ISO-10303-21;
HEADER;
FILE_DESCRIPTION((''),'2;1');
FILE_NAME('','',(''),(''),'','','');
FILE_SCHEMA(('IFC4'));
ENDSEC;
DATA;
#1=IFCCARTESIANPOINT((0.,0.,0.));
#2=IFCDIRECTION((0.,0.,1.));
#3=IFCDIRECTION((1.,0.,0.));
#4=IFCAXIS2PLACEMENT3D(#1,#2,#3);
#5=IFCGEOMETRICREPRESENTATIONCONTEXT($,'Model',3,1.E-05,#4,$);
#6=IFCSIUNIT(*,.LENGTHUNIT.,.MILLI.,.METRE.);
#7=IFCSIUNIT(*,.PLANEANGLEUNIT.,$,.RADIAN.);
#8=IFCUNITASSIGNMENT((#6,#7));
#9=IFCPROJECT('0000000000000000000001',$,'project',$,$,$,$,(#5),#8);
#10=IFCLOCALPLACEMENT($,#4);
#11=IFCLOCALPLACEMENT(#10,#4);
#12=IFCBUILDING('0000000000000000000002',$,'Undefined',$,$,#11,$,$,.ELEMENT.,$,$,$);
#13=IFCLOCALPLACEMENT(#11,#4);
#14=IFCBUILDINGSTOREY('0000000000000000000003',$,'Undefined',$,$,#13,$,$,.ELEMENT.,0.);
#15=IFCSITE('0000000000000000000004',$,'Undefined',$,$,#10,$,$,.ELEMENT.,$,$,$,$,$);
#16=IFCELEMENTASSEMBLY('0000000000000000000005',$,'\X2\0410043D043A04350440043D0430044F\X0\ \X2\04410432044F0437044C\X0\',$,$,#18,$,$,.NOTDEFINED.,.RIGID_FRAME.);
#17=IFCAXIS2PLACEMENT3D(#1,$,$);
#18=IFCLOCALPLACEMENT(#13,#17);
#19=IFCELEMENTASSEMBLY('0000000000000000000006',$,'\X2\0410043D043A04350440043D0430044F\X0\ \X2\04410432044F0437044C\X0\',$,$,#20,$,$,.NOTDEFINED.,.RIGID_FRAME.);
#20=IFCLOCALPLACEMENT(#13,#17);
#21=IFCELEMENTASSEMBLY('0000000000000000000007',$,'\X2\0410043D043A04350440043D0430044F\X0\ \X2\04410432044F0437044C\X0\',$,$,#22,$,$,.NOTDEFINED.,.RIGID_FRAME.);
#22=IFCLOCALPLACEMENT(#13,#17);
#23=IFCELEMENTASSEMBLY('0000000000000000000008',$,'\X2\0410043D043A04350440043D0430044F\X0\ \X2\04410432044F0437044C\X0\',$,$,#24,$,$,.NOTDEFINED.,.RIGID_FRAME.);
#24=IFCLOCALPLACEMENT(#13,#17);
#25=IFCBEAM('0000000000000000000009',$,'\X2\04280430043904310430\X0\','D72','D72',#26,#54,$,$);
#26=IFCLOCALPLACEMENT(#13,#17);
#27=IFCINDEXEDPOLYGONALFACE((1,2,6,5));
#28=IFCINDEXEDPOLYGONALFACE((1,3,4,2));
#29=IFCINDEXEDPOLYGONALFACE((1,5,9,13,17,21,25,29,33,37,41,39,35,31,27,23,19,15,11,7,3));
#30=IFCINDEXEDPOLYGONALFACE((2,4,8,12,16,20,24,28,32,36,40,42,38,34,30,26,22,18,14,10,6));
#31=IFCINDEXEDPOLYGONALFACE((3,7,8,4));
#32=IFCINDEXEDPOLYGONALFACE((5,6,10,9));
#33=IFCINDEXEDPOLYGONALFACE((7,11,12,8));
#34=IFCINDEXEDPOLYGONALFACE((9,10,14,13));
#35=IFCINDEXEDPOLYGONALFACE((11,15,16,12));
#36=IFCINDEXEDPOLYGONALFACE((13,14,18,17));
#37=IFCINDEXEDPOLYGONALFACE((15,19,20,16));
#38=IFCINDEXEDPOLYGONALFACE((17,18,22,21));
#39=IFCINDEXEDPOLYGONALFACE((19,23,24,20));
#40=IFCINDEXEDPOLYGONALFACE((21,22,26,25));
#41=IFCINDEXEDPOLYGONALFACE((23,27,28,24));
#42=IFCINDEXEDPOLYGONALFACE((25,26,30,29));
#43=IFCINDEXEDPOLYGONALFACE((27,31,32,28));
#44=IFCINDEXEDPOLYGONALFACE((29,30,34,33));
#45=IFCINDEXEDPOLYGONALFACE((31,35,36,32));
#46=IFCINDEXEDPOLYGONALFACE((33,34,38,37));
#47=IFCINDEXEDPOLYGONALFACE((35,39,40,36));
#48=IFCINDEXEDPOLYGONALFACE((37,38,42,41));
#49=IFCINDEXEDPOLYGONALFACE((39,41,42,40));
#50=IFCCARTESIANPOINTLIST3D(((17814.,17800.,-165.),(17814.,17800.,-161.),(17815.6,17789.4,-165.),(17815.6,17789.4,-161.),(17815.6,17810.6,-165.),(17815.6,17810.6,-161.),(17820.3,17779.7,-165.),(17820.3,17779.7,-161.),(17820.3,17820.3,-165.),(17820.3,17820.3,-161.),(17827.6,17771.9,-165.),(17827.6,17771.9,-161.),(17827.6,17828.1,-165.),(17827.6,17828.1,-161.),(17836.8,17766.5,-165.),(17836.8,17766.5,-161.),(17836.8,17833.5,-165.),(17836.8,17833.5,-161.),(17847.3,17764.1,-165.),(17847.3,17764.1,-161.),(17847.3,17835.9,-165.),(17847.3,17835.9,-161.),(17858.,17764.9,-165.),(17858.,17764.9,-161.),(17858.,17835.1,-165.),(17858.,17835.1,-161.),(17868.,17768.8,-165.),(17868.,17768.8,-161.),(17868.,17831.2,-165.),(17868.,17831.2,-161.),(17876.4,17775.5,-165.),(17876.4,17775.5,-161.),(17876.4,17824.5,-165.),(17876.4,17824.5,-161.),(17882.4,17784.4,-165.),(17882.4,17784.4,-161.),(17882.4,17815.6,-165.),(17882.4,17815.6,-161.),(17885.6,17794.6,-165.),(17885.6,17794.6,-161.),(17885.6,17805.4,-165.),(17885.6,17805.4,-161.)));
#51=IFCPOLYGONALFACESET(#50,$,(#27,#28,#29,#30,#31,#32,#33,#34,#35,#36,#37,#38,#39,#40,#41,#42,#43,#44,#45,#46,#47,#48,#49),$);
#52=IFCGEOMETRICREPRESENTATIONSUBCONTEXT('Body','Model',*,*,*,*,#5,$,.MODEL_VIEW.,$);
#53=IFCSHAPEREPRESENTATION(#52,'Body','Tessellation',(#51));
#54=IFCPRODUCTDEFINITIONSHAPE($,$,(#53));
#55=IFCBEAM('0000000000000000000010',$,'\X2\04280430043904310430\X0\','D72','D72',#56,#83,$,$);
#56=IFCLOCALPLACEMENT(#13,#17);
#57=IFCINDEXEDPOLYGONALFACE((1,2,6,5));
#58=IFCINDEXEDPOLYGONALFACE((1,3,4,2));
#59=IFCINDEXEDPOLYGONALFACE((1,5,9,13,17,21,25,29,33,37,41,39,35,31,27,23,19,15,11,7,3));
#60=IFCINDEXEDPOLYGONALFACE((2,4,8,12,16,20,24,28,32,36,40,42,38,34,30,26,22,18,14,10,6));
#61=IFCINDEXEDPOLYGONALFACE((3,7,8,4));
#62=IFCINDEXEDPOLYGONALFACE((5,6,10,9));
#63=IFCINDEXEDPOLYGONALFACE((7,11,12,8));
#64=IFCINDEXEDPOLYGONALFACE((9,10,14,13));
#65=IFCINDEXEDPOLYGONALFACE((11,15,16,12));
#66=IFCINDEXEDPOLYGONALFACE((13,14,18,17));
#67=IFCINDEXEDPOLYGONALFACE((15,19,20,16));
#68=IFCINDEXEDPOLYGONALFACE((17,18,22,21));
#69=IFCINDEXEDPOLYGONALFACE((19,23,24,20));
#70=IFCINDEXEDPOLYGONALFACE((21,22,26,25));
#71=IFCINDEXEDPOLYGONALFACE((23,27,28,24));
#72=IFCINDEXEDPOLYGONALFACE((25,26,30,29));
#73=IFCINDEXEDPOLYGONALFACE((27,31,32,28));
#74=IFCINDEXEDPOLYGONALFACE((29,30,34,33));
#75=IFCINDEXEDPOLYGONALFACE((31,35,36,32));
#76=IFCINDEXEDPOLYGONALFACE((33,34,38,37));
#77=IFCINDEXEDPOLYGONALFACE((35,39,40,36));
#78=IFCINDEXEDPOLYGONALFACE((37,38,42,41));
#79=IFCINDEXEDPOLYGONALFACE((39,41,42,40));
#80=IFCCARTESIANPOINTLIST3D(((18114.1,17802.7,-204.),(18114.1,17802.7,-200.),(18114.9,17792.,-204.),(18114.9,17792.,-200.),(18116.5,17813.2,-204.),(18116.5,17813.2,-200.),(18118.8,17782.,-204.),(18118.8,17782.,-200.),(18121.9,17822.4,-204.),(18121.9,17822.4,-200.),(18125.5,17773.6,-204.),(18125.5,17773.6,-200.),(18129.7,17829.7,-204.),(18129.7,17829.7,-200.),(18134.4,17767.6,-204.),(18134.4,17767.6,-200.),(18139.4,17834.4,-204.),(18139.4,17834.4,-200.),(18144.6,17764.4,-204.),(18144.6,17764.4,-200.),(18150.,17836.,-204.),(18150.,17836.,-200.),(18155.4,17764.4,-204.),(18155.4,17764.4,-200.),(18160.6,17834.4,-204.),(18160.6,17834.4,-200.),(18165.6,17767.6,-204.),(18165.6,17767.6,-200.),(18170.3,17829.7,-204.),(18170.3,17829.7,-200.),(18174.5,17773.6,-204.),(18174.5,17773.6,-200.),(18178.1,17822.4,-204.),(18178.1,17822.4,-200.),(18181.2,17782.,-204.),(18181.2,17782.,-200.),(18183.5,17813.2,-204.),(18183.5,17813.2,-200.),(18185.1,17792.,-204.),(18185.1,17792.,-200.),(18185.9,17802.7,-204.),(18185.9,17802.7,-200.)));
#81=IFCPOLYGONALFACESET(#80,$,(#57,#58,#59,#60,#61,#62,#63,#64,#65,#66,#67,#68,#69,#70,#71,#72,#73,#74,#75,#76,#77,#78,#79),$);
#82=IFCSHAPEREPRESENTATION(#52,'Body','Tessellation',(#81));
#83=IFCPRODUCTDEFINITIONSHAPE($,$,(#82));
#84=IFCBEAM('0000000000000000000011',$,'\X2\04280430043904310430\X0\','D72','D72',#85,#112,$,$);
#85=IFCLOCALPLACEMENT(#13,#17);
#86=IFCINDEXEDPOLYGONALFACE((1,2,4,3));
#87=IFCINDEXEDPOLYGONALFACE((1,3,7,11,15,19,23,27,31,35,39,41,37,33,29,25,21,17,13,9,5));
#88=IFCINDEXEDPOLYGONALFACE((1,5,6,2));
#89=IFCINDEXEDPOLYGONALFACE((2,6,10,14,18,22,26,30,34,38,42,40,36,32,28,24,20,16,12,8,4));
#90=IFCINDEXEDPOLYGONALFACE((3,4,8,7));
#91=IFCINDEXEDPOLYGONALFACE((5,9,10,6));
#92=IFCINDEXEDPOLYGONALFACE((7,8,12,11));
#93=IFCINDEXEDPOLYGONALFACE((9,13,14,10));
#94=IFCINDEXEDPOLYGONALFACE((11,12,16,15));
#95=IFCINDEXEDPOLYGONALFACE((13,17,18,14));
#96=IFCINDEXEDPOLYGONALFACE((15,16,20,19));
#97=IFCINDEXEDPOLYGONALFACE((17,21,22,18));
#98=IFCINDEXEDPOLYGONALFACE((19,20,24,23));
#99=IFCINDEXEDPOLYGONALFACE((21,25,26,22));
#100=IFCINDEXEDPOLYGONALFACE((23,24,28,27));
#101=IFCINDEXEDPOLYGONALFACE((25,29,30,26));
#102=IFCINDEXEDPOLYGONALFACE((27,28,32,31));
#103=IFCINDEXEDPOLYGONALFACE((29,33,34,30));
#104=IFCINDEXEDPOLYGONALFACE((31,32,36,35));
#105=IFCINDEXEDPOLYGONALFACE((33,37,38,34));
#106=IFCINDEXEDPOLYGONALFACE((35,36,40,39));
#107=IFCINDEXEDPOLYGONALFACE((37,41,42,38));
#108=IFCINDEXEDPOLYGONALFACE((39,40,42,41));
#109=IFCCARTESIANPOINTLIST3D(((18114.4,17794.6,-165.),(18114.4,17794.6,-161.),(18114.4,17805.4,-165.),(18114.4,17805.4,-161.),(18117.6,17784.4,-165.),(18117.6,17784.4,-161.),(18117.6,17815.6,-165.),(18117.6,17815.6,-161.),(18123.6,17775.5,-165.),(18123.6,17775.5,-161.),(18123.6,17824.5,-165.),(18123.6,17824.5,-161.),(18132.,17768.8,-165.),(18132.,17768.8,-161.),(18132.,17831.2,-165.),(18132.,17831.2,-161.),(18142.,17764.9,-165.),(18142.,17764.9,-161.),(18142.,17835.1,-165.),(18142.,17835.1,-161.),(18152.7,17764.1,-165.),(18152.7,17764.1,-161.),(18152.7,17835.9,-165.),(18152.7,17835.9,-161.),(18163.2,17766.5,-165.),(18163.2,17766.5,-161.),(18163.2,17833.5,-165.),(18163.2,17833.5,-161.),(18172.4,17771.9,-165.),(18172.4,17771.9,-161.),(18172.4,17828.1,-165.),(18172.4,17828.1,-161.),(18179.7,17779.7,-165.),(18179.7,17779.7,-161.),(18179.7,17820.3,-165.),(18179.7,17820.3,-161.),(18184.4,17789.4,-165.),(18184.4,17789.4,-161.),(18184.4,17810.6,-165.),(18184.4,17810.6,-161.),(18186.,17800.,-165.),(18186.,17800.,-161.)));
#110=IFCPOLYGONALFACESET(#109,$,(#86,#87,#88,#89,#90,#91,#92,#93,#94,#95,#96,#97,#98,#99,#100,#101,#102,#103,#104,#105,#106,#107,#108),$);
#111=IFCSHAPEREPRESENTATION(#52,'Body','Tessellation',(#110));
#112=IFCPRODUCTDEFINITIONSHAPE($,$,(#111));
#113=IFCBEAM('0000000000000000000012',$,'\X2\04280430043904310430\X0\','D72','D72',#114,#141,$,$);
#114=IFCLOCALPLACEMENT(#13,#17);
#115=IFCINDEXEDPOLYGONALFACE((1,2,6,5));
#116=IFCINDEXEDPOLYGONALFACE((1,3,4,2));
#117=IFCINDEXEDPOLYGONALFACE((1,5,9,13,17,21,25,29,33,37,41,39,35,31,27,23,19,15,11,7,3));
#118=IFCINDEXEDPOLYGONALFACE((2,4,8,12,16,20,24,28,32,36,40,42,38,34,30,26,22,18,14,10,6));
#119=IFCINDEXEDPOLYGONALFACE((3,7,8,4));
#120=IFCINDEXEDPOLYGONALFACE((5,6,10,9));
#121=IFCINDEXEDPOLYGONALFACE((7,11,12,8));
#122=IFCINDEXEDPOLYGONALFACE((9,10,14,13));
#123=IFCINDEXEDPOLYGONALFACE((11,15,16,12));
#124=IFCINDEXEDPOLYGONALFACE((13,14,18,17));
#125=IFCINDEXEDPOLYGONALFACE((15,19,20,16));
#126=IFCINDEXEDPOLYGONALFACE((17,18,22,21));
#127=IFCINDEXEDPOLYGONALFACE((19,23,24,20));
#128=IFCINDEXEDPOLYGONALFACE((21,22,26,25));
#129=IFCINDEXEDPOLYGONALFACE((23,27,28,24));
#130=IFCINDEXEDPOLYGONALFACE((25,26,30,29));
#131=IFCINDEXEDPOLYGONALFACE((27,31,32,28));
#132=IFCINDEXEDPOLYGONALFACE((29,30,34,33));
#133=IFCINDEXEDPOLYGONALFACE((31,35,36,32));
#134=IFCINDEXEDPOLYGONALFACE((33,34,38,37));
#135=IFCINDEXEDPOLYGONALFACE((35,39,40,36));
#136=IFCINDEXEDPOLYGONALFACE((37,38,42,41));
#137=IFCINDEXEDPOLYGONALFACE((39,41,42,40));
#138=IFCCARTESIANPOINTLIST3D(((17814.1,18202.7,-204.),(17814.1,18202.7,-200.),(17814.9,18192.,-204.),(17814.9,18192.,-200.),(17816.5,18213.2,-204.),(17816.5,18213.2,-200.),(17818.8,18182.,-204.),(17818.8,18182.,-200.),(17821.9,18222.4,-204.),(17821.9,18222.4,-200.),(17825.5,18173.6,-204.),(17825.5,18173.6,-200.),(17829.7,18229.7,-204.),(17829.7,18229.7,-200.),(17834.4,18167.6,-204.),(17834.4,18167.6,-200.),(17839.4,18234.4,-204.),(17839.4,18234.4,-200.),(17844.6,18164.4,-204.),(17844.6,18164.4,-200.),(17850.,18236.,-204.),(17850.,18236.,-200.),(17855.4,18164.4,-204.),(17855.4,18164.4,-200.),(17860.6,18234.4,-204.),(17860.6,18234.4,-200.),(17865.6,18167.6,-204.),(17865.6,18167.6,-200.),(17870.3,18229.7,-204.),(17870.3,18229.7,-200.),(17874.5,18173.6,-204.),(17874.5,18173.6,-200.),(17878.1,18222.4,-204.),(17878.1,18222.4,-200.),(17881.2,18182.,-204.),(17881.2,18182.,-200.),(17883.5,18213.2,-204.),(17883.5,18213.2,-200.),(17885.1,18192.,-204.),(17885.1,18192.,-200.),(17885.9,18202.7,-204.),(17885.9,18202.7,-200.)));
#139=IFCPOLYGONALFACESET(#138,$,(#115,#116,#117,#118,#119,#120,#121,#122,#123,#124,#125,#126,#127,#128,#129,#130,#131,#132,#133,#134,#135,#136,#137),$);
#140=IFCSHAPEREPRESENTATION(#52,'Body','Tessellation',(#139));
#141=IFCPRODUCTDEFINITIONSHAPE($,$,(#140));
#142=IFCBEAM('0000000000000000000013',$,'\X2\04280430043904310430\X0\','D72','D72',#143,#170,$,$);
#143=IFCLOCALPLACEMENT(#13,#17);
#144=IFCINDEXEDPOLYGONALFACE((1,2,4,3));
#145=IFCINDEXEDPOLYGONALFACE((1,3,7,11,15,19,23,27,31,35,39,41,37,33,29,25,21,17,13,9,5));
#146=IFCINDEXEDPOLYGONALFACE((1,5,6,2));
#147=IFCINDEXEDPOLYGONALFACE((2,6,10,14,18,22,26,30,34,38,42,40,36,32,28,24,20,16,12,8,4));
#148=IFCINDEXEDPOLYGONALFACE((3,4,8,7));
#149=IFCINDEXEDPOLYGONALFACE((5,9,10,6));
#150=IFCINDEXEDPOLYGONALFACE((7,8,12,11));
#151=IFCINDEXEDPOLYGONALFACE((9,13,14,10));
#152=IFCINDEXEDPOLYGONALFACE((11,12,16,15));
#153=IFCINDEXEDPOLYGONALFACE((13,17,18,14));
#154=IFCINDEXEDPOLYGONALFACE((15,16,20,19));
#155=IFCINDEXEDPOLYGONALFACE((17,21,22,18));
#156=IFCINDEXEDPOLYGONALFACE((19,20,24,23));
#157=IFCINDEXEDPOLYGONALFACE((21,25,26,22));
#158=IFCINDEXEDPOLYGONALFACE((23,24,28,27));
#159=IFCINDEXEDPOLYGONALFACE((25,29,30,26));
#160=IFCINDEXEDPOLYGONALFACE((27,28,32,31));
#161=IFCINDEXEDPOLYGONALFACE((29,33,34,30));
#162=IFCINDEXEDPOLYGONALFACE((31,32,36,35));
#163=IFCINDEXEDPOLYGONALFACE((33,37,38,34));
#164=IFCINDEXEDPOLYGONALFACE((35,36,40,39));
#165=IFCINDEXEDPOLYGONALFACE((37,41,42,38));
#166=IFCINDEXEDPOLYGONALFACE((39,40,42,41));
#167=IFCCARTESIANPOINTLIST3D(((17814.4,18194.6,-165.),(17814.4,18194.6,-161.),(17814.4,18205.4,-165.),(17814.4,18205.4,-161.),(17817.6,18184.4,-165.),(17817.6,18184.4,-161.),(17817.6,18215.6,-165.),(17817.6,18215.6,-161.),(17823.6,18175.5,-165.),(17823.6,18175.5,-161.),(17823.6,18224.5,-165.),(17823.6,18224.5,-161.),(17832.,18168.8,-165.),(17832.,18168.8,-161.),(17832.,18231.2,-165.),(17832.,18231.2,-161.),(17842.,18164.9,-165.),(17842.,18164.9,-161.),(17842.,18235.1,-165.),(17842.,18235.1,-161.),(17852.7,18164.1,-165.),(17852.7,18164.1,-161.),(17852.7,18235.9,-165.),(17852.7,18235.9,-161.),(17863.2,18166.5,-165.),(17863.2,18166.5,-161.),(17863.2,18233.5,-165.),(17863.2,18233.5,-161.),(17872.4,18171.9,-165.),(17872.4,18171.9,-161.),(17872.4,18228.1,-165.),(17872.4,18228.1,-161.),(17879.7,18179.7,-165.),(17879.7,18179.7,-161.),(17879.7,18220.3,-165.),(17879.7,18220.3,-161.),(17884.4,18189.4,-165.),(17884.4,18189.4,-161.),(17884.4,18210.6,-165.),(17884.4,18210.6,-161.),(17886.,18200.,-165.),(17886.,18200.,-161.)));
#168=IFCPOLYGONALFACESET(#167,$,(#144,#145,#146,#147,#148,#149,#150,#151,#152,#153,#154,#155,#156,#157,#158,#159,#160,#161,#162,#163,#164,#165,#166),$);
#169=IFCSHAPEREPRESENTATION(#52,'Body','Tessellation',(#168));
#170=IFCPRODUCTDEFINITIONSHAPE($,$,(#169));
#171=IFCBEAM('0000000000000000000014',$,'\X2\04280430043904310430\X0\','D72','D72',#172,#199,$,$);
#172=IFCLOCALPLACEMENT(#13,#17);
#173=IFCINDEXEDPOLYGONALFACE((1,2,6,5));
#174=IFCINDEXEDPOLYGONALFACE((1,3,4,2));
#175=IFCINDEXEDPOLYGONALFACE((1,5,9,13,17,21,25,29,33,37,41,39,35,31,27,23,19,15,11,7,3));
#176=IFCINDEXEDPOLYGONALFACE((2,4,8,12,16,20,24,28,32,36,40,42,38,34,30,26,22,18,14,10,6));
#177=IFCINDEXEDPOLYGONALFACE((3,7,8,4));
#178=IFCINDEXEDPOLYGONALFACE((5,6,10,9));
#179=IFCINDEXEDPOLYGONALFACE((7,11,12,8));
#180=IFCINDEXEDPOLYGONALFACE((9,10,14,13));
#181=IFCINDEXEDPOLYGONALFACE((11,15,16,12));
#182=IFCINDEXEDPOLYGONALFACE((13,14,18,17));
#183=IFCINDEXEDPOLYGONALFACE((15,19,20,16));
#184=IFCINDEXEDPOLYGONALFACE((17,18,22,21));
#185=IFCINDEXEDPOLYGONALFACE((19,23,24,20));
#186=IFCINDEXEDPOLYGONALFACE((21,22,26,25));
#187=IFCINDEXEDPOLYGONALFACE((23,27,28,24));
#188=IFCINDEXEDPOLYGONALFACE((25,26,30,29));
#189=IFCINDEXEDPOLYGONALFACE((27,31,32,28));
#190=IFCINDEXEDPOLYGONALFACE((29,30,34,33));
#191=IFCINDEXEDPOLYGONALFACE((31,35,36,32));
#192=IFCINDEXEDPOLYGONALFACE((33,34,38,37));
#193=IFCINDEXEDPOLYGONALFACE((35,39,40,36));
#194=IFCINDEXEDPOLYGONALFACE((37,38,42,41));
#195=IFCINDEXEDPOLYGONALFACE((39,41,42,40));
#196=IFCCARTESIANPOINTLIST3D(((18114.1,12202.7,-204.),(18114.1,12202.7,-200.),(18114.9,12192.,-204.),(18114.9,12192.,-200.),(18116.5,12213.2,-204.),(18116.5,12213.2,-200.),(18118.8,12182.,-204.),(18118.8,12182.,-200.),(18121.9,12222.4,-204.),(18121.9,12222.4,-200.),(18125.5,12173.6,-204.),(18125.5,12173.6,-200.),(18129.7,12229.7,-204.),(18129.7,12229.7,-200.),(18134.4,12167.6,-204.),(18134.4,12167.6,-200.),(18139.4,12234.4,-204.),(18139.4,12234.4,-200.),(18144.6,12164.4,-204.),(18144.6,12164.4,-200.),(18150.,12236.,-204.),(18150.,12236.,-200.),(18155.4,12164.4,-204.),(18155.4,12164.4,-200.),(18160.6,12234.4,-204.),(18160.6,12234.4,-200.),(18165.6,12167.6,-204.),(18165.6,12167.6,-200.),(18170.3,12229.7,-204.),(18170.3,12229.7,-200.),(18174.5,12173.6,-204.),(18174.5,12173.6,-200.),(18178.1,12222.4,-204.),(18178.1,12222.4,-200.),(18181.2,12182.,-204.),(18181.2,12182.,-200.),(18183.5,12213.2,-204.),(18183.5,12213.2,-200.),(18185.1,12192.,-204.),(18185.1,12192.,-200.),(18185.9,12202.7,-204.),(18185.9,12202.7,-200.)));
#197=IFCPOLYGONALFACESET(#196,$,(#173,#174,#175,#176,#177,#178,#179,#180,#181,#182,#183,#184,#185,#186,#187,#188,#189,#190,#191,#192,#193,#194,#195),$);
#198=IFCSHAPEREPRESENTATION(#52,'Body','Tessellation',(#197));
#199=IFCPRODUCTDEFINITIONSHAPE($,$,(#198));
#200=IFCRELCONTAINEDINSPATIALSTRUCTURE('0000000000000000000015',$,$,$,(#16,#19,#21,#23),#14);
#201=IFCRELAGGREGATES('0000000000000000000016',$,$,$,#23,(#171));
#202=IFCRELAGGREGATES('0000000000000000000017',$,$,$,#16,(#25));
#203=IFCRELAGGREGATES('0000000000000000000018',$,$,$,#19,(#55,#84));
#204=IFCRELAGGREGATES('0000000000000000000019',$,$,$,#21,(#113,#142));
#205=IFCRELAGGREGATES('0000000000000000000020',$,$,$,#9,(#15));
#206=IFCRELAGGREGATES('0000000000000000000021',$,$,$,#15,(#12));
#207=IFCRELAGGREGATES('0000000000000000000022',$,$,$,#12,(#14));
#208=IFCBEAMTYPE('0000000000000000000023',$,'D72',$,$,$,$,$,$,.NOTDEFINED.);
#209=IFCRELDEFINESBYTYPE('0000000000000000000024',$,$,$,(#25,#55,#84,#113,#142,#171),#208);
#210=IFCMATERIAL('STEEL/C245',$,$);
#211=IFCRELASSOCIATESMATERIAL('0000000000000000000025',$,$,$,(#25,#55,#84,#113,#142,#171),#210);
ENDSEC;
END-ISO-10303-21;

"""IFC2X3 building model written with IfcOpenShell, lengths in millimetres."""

from ifc_helpers import new_model, si_unit, frame, origin_with_axes, origin_2d_with_axis, place, context, subcontext, project, spatial, circle, extrude, material, type_object, element, aggregate, save


model = new_model("IFC2X3")

# Units and contexts
model_context = context("Model", 3, precision=1e-05, world=origin_with_axes())
body_context = subcontext(model_context, "Body", "Model", "MODEL_VIEW")
ifc_project = project(units=[si_unit("LENGTHUNIT", "METRE", prefix="MILLI"), si_unit("PLANEANGLEUNIT", "RADIAN")], contexts=[model_context])

# Site, building, storey
site_placement = place(None, origin_with_axes())
site = spatial("IfcSite", under=ifc_project, at=site_placement, Name="Undefined", CompositionType="ELEMENT")
building_placement = place(site_placement, origin_with_axes())
building = spatial("IfcBuilding", under=site, at=building_placement, Name="Undefined", CompositionType="ELEMENT")
storey_placement = place(building_placement, origin_with_axes())
storey = spatial("IfcBuildingStorey", under=building, at=storey_placement, Name="Undefined", CompositionType="ELEMENT", Elevation=0.0)

# Element assemblies
assembly_1_placement = place(storey_placement, origin_with_axes())
assembly_1 = element("IfcElementAssembly", 1, at=assembly_1_placement, inside=storey, Name="Анкерная связь", AssemblyPlace="NOTDEFINED", PredefinedType="RIGID_FRAME")
ifc_material_1 = material(Name="STEEL/C245")
assembly_2_placement = place(storey_placement, origin_with_axes())
assembly_2 = element("IfcElementAssembly", 2, at=assembly_2_placement, inside=storey, Name="Анкерная связь", AssemblyPlace="NOTDEFINED", PredefinedType="RIGID_FRAME")
assembly_3_placement = place(storey_placement, origin_with_axes())
assembly_3 = element("IfcElementAssembly", 3, at=assembly_3_placement, inside=storey, Name="Анкерная связь", AssemblyPlace="NOTDEFINED", PredefinedType="RIGID_FRAME")

# Element assembly
assembly_4_placement = place(storey_placement, origin_with_axes())
assembly_4 = element("IfcElementAssembly", 4, at=assembly_4_placement, inside=storey, Name="Анкерная связь", AssemblyPlace="NOTDEFINED", PredefinedType="RIGID_FRAME")

# Beams
beam_type_1 = type_object("IfcBeamType", Name="D72", PredefinedType="NOTDEFINED")
beam_1_placement = place(assembly_1_placement, frame((17850.0, 17800.0, -161.0), z_axis=(0.0, -1.0, 0.0), x_axis=(0.0, 0.0, -1.0)))
beam_1 = element("IfcBeam", 5, at=beam_1_placement, type_object=beam_type_1, material=ifc_material_1, Name="Шайба", Description="D72", ObjectType="D72", context=body_context, shape_type="SweptSolid", body=[
    extrude(circle(Radius=36.0, at=origin_2d_with_axis()), frame((4.0, 0.0, 0.0), z_axis=(-1.0, 0.0, 0.0), x_axis=(0.0, -1.0, 0.0)), (0.0, 0.0, 1.0), 4.0),
])
beam_2_placement = place(assembly_2_placement, frame((18150.0, 17800.0, -200.0), z_axis=(-1.0, 0.0, 0.0), x_axis=(0.0, 0.0, -1.0)))
beam_2 = element("IfcBeam", 6, at=beam_2_placement, type_object=beam_type_1, material=ifc_material_1, Name="Шайба", Description="D72", ObjectType="D72", context=body_context, shape_type="SweptSolid", body=[
    extrude(circle(Radius=36.0, at=origin_2d_with_axis()), frame((4.0, 0.0, 0.0), z_axis=(-1.0, 0.0, 0.0), x_axis=(0.0, -1.0, 0.0)), (0.0, 0.0, 1.0), 4.0),
])
beam_3_placement = place(assembly_2_placement, frame((18150.0, 17800.0, -161.0), z_axis=(0.0, 1.0, 0.0), x_axis=(0.0, 0.0, -1.0)))
beam_3 = element("IfcBeam", 7, at=beam_3_placement, type_object=beam_type_1, material=ifc_material_1, Name="Шайба", Description="D72", ObjectType="D72", context=body_context, shape_type="SweptSolid", body=[
    extrude(circle(Radius=36.0, at=origin_2d_with_axis()), frame((4.0, 0.0, 0.0), z_axis=(-1.0, 0.0, 0.0), x_axis=(0.0, -1.0, 0.0)), (0.0, 0.0, 1.0), 4.0),
])
beam_4_placement = place(assembly_3_placement, frame((17850.0, 18200.0, -200.0), z_axis=(-1.0, 0.0, 0.0), x_axis=(0.0, 0.0, -1.0)))
beam_4 = element("IfcBeam", 8, at=beam_4_placement, type_object=beam_type_1, material=ifc_material_1, Name="Шайба", Description="D72", ObjectType="D72", context=body_context, shape_type="SweptSolid", body=[
    extrude(circle(Radius=36.0, at=origin_2d_with_axis()), frame((4.0, 0.0, 0.0), z_axis=(-1.0, 0.0, 0.0), x_axis=(0.0, -1.0, 0.0)), (0.0, 0.0, 1.0), 4.0),
])
beam_5_placement = place(assembly_3_placement, frame((17850.0, 18200.0, -161.0), z_axis=(0.0, 1.0, 0.0), x_axis=(0.0, 0.0, -1.0)))
beam_5 = element("IfcBeam", 9, at=beam_5_placement, type_object=beam_type_1, material=ifc_material_1, Name="Шайба", Description="D72", ObjectType="D72", context=body_context, shape_type="SweptSolid", body=[
    extrude(circle(Radius=36.0, at=origin_2d_with_axis()), frame((4.0, 0.0, 0.0), z_axis=(-1.0, 0.0, 0.0), x_axis=(0.0, -1.0, 0.0)), (0.0, 0.0, 1.0), 4.0),
])
beam_6_placement = place(assembly_4_placement, frame((18150.0, 12200.0, -200.0), z_axis=(-1.0, 0.0, 0.0), x_axis=(0.0, 0.0, -1.0)))
beam_6 = element("IfcBeam", 10, at=beam_6_placement, type_object=beam_type_1, material=ifc_material_1, Name="Шайба", Description="D72", ObjectType="D72", context=body_context, shape_type="SweptSolid", body=[
    extrude(circle(Radius=36.0, at=origin_2d_with_axis()), frame((4.0, 0.0, 0.0), z_axis=(-1.0, 0.0, 0.0), x_axis=(0.0, -1.0, 0.0)), (0.0, 0.0, 1.0), 4.0),
])

aggregate(assembly_4, [beam_6])

aggregate(assembly_1, [beam_1])
aggregate(assembly_2, [beam_2, beam_3])
aggregate(assembly_3, [beam_4, beam_5])

save(model, "model.ifc")
